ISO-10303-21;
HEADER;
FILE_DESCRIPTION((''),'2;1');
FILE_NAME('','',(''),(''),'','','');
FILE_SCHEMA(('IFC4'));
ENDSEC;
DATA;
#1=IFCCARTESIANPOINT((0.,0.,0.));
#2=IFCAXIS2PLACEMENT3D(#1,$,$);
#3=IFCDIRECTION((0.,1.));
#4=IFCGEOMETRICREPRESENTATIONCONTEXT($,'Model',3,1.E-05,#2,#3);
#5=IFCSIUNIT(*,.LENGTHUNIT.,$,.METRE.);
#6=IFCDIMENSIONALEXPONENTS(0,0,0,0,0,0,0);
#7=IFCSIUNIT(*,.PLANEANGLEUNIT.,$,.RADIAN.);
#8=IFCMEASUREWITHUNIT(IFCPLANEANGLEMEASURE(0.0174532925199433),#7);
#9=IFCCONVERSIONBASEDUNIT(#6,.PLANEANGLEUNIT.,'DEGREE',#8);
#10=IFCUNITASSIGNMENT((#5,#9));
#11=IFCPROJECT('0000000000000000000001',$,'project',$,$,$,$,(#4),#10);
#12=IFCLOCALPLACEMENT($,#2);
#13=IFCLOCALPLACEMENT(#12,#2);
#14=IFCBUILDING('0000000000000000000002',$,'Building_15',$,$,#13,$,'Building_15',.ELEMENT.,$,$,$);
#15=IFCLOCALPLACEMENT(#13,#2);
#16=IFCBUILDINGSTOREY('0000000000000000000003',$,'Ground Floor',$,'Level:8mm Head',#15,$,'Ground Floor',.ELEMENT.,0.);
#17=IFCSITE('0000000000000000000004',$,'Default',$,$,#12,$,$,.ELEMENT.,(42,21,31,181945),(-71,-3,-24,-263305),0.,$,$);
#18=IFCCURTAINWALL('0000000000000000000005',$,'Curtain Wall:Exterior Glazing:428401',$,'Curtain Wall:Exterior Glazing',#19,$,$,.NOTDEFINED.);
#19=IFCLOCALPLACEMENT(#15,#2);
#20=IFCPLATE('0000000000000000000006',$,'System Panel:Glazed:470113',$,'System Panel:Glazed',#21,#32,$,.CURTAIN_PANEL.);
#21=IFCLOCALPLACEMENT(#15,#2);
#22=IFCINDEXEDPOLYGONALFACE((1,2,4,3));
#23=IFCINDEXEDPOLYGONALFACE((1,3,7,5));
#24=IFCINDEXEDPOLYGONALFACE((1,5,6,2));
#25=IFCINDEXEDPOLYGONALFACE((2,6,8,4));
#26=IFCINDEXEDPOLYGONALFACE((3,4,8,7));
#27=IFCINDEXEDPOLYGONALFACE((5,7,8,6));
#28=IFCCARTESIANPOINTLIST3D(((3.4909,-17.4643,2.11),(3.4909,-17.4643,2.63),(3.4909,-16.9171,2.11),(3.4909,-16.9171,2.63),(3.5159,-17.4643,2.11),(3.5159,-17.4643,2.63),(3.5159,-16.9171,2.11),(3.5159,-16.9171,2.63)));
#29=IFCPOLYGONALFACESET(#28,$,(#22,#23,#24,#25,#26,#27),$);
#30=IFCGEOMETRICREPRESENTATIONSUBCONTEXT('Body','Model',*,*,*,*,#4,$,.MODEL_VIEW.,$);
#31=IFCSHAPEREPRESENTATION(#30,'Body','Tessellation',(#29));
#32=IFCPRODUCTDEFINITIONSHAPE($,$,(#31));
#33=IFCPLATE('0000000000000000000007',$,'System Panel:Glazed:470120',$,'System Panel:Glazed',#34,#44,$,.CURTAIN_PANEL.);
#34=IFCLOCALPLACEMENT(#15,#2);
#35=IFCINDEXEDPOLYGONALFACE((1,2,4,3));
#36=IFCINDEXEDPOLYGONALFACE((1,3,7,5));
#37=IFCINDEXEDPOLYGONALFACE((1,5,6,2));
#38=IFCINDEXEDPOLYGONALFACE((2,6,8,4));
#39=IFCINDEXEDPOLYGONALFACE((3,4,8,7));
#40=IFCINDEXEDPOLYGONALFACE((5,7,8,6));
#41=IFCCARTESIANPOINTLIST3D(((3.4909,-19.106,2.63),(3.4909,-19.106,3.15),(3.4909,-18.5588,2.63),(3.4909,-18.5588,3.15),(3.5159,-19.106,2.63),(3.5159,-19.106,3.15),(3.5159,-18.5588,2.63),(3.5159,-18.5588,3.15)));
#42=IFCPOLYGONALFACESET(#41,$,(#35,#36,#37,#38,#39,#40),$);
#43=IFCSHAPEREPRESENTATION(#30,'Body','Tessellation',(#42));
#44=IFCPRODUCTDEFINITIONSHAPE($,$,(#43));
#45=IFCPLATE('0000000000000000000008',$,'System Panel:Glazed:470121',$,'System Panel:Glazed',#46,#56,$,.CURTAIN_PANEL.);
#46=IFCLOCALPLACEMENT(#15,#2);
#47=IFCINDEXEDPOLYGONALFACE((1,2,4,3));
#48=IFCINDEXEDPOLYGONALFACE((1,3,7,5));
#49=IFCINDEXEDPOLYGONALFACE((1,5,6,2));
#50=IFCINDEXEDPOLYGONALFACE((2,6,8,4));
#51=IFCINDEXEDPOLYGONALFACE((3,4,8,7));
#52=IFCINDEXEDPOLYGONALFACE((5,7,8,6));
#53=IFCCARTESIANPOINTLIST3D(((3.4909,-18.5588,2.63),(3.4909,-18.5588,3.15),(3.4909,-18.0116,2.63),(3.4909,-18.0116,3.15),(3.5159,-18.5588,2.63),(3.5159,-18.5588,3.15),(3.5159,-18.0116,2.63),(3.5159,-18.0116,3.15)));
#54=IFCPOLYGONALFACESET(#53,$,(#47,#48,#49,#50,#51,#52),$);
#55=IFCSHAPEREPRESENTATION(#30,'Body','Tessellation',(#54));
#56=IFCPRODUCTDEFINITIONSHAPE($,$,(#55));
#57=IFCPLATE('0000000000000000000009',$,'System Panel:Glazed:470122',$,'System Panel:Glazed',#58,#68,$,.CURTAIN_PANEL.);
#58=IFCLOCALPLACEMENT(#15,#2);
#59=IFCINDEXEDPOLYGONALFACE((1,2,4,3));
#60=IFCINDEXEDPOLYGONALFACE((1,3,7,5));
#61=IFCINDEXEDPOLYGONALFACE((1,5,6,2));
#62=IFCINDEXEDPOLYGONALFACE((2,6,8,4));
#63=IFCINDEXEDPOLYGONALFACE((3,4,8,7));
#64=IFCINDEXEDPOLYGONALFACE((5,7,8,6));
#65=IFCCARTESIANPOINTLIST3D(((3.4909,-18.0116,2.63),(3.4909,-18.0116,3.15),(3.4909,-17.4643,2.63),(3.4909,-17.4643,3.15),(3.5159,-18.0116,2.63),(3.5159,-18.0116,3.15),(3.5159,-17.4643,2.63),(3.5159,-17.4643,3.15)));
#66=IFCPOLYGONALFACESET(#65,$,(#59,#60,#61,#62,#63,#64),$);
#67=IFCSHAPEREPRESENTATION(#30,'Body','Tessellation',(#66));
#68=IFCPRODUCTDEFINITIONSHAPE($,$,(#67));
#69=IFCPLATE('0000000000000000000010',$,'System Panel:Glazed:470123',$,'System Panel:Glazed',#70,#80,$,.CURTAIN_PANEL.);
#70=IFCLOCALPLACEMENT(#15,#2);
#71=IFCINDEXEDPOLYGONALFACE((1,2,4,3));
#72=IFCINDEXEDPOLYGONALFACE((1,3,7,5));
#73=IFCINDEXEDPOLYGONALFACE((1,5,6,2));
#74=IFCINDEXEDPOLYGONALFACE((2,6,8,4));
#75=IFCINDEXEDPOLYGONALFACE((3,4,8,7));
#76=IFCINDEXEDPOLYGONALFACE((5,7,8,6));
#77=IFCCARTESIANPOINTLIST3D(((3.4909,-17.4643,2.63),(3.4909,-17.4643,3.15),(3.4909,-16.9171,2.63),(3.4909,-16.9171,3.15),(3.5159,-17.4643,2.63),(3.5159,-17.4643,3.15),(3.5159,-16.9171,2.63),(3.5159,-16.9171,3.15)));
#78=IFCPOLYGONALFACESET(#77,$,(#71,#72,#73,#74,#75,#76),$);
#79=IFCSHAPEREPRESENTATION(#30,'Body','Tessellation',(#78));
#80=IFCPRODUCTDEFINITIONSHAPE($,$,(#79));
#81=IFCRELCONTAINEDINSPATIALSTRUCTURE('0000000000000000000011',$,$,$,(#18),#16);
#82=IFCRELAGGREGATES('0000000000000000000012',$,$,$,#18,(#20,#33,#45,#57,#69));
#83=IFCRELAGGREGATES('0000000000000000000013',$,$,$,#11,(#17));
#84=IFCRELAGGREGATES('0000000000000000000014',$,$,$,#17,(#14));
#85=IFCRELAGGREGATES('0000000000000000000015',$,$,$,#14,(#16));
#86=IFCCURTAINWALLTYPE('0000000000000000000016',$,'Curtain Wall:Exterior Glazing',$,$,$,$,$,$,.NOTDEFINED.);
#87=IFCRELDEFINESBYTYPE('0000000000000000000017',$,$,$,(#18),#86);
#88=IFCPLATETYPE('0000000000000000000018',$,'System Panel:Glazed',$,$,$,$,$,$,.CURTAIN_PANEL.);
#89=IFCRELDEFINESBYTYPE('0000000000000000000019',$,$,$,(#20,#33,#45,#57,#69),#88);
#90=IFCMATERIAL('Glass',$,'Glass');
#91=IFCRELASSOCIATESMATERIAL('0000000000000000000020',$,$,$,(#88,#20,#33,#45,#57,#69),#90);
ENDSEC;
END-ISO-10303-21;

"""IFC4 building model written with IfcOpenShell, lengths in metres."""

from ifc_helpers import new_model, entity, si_unit, converted_unit, direction, frame, origin, place, context, subcontext, project, spatial, indexed_curve, outline, extrude, source, transform, mapped, material, type_object, type_shapes, element, aggregate, save


model = new_model("IFC4")

# Units and contexts
model_context = context("Model", 3, precision=1e-05, world=origin(), true_north=direction((0.0, 1.0)))
body_context = subcontext(model_context, "Body", "Model", "MODEL_VIEW")
ifc_project = project(units=[si_unit("LENGTHUNIT", "METRE"), converted_unit("PLANEANGLEUNIT", "DEGREE", entity("IfcPlaneAngleMeasure", 0.0174532925199433), si_unit("PLANEANGLEUNIT", "RADIAN"), dimensions=[0, 0, 0, 0, 0, 0, 0])], contexts=[model_context])

# Site, building, storey
site_placement = place(None, origin())
site = spatial("IfcSite", under=ifc_project, at=site_placement, Name="Default", CompositionType="ELEMENT", RefLatitude=(42, 21, 31, 181945), RefLongitude=(-71, -3, -24, -263305), RefElevation=0.0)
building_placement = place(site_placement, origin())
building = spatial("IfcBuilding", under=site, at=building_placement, Name="Building_15", LongName="Building_15", CompositionType="ELEMENT")
storey_placement = place(building_placement, origin())
storey = spatial("IfcBuildingStorey", under=building, at=storey_placement, Name="Ground Floor", ObjectType="Level:8mm Head", LongName="Ground Floor", CompositionType="ELEMENT", Elevation=0.0)

# Curtain wall, plates
curtain_wall_type = type_object("IfcCurtainWallType", Name="Curtain Wall:Exterior Glazing", PredefinedType="NOTDEFINED")
curtain_wall_placement = place(storey_placement, origin())
curtain_wall = element("IfcCurtainWall", 1, at=curtain_wall_placement, inside=storey, type_object=curtain_wall_type, Name="Curtain Wall:Exterior Glazing:428401", ObjectType="Curtain Wall:Exterior Glazing", PredefinedType="NOTDEFINED")
ifc_material_1 = material(Name="Glass", Category="Glass")
plate_type_1 = type_object("IfcPlateType", Name="System Panel:Glazed", PredefinedType="CURTAIN_PANEL", material=ifc_material_1)
shared_shape_1 = source(origin(), body_context, "Body", "SweptSolid", [
    extrude(outline(indexed_curve([(-0.0125, -0.2736), (0.0125, -0.2736), (0.0125, 0.2736), (-0.0125, 0.2736), (-0.0125, -0.2736)], self_intersect=False)), frame((0.0, 0.037, 0.0), z_axis=(0.0, 0.0, 1.0), x_axis=(0.0, 1.0, 0.0)), (0.0, 0.0, 1.0), 0.52),
])
type_shapes(plate_type_1, [shared_shape_1])
plate_1_placement = place(curtain_wall_placement, frame((3.5404, -17.1907, 2.11), z_axis=(0.0, 0.0, 1.0), x_axis=(0.0, 1.0, 0.0)))
plate_1 = element("IfcPlate", 2, at=plate_1_placement, type_object=plate_type_1, material=ifc_material_1, Name="System Panel:Glazed:470113", ObjectType="System Panel:Glazed", PredefinedType="CURTAIN_PANEL", context=body_context, shape_type="MappedRepresentation", body=[
    mapped(shared_shape_1, transform((0.0, 0.0, 0.0), scale=1.0)),
])
plate_2_placement = place(curtain_wall_placement, frame((3.5404, -18.8324, 2.63), z_axis=(0.0, 0.0, 1.0), x_axis=(0.0, 1.0, 0.0)))
plate_2 = element("IfcPlate", 3, at=plate_2_placement, type_object=plate_type_1, material=ifc_material_1, Name="System Panel:Glazed:470120", ObjectType="System Panel:Glazed", PredefinedType="CURTAIN_PANEL", context=body_context, shape_type="MappedRepresentation", body=[
    mapped(shared_shape_1, transform((0.0, 0.0, 0.0), scale=1.0)),
])
plate_3_placement = place(curtain_wall_placement, frame((3.5404, -18.2852, 2.63), z_axis=(0.0, 0.0, 1.0), x_axis=(0.0, 1.0, 0.0)))
plate_3 = element("IfcPlate", 4, at=plate_3_placement, type_object=plate_type_1, material=ifc_material_1, Name="System Panel:Glazed:470121", ObjectType="System Panel:Glazed", PredefinedType="CURTAIN_PANEL", context=body_context, shape_type="MappedRepresentation", body=[
    mapped(shared_shape_1, transform((0.0, 0.0, 0.0), scale=1.0)),
])
plate_4_placement = place(curtain_wall_placement, frame((3.5404, -17.738, 2.63), z_axis=(0.0, 0.0, 1.0), x_axis=(0.0, 1.0, 0.0)))
plate_4 = element("IfcPlate", 5, at=plate_4_placement, type_object=plate_type_1, material=ifc_material_1, Name="System Panel:Glazed:470122", ObjectType="System Panel:Glazed", PredefinedType="CURTAIN_PANEL", context=body_context, shape_type="MappedRepresentation", body=[
    mapped(shared_shape_1, transform((0.0, 0.0, 0.0), scale=1.0)),
])
plate_5_placement = place(curtain_wall_placement, frame((3.5404, -17.1907, 2.63), z_axis=(0.0, 0.0, 1.0), x_axis=(0.0, 1.0, 0.0)))
plate_5 = element("IfcPlate", 6, at=plate_5_placement, type_object=plate_type_1, material=ifc_material_1, Name="System Panel:Glazed:470123", ObjectType="System Panel:Glazed", PredefinedType="CURTAIN_PANEL", context=body_context, shape_type="MappedRepresentation", body=[
    mapped(shared_shape_1, transform((0.0, 0.0, 0.0), scale=1.0)),
])
aggregate(curtain_wall, [plate_1, plate_2, plate_3, plate_4, plate_5])

save(model, "model.ifc")
